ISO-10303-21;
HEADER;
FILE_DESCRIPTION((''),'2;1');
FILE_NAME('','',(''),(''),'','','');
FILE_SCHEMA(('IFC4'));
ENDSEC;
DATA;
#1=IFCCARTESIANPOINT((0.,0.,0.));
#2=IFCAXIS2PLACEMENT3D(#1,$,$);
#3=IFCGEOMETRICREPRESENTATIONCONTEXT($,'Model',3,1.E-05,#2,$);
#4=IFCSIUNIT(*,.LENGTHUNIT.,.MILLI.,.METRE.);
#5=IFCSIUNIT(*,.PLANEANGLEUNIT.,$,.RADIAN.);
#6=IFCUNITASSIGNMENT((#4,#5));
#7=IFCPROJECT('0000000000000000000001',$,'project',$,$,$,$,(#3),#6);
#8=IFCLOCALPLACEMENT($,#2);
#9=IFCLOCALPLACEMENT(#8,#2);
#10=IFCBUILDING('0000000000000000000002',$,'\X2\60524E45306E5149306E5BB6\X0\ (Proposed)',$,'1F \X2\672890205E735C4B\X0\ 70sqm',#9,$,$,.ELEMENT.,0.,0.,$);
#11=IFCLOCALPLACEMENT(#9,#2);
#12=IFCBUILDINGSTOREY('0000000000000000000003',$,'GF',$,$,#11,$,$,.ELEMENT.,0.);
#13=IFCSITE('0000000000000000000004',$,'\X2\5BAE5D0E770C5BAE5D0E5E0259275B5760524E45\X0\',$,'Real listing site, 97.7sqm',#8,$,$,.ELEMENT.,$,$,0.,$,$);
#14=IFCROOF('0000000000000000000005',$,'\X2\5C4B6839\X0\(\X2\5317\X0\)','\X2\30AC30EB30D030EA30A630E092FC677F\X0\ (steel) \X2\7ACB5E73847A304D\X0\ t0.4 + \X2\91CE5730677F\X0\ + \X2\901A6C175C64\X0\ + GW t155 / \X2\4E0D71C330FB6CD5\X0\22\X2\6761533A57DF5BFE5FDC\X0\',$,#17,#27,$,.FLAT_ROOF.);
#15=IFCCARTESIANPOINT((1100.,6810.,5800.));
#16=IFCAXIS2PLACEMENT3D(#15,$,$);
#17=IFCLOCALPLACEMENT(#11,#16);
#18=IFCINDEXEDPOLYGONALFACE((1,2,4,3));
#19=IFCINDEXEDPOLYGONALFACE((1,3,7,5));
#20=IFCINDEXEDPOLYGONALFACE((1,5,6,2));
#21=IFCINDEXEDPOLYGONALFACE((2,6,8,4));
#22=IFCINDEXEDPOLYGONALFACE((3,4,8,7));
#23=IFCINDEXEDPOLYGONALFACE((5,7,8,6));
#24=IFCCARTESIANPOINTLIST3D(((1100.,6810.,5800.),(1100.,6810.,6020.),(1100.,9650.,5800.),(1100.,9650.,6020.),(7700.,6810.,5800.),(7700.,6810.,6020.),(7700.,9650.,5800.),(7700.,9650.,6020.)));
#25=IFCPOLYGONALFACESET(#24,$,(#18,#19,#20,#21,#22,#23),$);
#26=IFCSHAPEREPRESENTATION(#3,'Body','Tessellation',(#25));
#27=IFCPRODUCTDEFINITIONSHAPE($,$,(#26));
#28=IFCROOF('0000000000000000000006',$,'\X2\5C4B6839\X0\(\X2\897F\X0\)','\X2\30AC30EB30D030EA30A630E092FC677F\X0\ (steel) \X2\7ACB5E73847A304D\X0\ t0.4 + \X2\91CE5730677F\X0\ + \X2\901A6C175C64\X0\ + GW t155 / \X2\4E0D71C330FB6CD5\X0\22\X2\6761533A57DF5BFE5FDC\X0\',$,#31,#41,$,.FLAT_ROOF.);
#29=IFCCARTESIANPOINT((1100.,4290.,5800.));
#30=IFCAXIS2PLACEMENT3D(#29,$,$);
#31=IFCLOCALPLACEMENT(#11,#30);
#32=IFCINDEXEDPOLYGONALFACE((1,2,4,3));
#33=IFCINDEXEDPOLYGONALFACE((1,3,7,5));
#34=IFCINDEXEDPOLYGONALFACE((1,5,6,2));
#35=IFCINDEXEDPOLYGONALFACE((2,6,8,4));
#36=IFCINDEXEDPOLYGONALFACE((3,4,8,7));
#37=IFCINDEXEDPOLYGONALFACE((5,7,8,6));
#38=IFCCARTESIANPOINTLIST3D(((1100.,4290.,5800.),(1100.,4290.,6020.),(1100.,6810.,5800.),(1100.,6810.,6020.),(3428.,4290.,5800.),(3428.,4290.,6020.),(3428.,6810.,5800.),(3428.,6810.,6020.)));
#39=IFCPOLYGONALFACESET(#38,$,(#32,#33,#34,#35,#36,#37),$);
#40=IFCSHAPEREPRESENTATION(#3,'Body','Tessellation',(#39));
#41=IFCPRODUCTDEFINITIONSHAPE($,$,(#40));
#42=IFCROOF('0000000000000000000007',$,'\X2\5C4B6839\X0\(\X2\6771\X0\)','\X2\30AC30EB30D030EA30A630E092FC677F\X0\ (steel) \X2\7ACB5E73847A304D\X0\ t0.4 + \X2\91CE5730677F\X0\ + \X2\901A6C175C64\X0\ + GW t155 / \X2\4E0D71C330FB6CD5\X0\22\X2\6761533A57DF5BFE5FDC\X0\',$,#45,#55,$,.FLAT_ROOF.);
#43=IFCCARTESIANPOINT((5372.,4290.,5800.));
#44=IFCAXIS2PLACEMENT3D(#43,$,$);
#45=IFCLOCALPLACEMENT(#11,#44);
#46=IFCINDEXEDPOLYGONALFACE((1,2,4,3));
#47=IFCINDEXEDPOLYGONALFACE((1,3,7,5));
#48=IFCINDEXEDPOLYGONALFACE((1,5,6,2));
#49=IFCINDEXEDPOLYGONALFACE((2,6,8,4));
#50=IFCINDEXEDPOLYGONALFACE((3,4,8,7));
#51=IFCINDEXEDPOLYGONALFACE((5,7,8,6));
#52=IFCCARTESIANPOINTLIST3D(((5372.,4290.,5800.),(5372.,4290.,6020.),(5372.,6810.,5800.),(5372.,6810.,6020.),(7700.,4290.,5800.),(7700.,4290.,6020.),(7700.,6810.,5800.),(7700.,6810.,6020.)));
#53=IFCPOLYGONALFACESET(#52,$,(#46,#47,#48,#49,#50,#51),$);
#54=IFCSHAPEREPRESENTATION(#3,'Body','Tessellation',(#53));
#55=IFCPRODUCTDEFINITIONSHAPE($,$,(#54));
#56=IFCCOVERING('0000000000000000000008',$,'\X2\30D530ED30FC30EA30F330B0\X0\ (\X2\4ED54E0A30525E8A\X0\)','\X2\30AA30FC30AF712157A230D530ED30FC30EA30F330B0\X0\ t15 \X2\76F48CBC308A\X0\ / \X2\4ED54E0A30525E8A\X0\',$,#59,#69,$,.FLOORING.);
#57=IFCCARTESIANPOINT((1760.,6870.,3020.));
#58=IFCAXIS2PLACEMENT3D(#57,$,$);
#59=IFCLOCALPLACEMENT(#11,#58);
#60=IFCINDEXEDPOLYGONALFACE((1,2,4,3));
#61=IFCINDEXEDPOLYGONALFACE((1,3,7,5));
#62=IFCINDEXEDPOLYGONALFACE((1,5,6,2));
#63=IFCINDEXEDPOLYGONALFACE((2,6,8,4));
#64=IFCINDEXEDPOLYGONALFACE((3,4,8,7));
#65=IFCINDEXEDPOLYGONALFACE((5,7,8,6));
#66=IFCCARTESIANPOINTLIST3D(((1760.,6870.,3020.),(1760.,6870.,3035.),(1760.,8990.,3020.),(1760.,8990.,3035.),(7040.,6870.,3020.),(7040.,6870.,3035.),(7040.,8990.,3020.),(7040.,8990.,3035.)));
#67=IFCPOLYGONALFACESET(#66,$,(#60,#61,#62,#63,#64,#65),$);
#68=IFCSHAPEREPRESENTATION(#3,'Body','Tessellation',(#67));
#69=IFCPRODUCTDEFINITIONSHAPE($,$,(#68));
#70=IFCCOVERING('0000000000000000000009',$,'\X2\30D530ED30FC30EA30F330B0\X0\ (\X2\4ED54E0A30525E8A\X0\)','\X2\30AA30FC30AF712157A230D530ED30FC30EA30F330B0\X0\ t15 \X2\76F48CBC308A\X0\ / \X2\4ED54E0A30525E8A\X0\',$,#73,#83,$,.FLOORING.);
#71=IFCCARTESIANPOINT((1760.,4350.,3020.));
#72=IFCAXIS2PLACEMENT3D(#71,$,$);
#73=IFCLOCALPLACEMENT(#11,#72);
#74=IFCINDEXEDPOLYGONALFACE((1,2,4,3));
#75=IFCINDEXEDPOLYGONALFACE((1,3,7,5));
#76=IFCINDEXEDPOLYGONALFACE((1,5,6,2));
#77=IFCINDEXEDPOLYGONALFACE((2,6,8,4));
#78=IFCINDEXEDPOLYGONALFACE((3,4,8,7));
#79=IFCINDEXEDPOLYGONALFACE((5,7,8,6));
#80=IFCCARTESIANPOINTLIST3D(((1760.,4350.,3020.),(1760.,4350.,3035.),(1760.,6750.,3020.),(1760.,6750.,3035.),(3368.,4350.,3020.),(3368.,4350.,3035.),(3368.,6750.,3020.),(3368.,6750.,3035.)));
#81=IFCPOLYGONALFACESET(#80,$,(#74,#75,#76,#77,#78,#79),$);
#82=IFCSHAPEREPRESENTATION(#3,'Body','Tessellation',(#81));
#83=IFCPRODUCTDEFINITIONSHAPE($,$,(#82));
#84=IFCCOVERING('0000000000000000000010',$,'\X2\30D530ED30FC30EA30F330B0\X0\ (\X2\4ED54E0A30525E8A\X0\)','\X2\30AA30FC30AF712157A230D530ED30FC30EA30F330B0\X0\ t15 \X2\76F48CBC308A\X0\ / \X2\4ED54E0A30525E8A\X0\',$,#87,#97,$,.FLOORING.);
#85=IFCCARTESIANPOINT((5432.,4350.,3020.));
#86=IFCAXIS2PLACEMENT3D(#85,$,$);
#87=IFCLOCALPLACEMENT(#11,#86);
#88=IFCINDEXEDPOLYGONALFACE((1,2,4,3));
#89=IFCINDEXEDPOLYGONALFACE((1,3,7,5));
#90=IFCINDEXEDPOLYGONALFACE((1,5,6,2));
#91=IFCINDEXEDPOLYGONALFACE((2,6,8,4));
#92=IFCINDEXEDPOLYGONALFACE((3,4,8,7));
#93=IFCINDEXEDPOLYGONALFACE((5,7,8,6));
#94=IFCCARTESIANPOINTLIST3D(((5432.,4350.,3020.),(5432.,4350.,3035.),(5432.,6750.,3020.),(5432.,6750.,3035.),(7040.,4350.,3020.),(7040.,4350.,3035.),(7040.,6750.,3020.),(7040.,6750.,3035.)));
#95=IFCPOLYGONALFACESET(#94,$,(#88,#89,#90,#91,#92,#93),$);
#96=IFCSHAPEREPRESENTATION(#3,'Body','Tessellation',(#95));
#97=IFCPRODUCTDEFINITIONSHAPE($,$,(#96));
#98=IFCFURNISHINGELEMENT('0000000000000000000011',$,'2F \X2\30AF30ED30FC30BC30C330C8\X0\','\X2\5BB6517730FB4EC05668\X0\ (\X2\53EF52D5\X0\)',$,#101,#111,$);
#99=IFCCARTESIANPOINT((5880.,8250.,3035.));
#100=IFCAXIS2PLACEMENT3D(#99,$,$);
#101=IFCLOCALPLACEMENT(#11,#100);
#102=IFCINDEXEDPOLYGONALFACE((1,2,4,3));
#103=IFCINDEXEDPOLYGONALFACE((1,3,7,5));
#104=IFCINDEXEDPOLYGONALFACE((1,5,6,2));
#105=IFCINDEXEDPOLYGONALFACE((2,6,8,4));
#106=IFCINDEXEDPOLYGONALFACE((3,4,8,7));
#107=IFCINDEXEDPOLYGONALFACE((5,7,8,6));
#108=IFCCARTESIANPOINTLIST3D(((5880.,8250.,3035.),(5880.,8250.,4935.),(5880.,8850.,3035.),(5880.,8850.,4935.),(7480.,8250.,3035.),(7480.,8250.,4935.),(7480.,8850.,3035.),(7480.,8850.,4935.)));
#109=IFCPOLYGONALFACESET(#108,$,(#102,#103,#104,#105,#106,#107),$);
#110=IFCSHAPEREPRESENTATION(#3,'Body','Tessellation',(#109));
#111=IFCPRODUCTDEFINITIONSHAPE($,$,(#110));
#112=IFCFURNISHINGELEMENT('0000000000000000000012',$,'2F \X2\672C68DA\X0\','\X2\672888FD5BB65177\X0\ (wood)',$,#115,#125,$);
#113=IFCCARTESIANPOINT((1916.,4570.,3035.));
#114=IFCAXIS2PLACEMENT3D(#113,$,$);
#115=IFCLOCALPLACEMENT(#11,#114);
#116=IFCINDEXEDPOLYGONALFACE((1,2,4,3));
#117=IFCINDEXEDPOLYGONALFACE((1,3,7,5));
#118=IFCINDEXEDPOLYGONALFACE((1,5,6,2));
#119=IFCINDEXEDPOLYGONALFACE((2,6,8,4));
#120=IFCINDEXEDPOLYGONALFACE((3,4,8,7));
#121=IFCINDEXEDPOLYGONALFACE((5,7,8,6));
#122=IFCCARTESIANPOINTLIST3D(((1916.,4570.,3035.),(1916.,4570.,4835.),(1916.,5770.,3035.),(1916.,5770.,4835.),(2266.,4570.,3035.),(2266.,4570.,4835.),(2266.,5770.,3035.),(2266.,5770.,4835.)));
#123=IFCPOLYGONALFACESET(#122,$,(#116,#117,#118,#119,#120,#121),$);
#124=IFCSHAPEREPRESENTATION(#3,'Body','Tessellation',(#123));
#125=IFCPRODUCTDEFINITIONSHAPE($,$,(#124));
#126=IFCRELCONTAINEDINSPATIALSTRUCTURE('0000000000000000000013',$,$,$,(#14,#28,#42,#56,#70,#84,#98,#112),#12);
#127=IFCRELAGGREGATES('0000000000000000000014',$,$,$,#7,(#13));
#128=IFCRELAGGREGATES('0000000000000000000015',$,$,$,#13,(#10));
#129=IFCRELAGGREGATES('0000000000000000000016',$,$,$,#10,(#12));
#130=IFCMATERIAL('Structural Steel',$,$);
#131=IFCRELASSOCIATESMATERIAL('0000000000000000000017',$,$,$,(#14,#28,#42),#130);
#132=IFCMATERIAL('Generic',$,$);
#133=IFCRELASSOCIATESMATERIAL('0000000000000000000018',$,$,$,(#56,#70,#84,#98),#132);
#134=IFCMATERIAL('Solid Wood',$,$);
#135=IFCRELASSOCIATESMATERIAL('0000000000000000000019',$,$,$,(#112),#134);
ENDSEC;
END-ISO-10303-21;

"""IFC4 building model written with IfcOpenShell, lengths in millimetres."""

from ifc_helpers import new_model, si_unit, frame, frame_2d, origin, place, context, project, spatial, rectangle, extrude, material, element, save


model = new_model("IFC4")

# Units and contexts
model_context = context("Model", 3, precision=1e-05, world=origin())
ifc_project = project(units=[si_unit("LENGTHUNIT", "METRE", prefix="MILLI"), si_unit("PLANEANGLEUNIT", "RADIAN")], contexts=[model_context])

# Site, building, storey
site_placement = place(None, origin())
site = spatial("IfcSite", under=ifc_project, at=site_placement, Name="宮崎県宮崎市大字恒久", ObjectType="Real listing site, 97.7sqm", CompositionType="ELEMENT", RefElevation=0.0)
building_placement = place(site_placement, origin())
building = spatial("IfcBuilding", under=site, at=building_placement, Name="恒久の光の家 (Proposed)", ObjectType="1F 木造平屋 70sqm", CompositionType="ELEMENT", ElevationOfRefHeight=0.0, ElevationOfTerrain=0.0)
storey_placement = place(building_placement, origin())
storey = spatial("IfcBuildingStorey", under=building, at=storey_placement, Name="GF", CompositionType="ELEMENT", Elevation=0.0)

# Shared definitions
ifc_material_1 = material(Name="Solid Wood")

# Shared definitions
ifc_material_2 = material(Name="Generic")

# Roofs
ifc_material_3 = material(Name="Structural Steel")
for number, where, name in (
    (1, (1100.0, 6810.0, 5800.0), "屋根(北)"),
):
    element("IfcRoof", number, at=place(storey_placement, frame(where)), inside=storey, material=ifc_material_3, Name=name, Description="ガルバリウム鋼板 (steel) 立平葺き t0.4 + 野地板 + 通気層 + GW t155 / 不燃・法22条区域対応", PredefinedType="FLAT_ROOF", context=model_context, shape_type="SweptSolid", body=[
        extrude(rectangle(XDim=6600.0, YDim=2840.0, at=frame_2d((3300.0, 1420.0))), frame((1100.0, 6810.0, 5800.0)), (0.0, 0.0, 1.0), 220.0),
    ])
roof_1_placement = place(storey_placement, frame((1100.0, 4290.0, 5800.0)))
element("IfcRoof", 2, at=roof_1_placement, inside=storey, material=ifc_material_3, Name="屋根(西)", Description="ガルバリウム鋼板 (steel) 立平葺き t0.4 + 野地板 + 通気層 + GW t155 / 不燃・法22条区域対応", PredefinedType="FLAT_ROOF", context=model_context, shape_type="SweptSolid", body=[
    extrude(rectangle(XDim=2328.0, YDim=2520.0, at=frame_2d((1164.0, 1260.0))), frame((1100.0, 4290.0, 5800.0)), (0.0, 0.0, 1.0), 220.0),
])
roof_2_placement = place(storey_placement, frame((5372.0, 4290.0, 5800.0)))
element("IfcRoof", 3, at=roof_2_placement, inside=storey, material=ifc_material_3, Name="屋根(東)", Description="ガルバリウム鋼板 (steel) 立平葺き t0.4 + 野地板 + 通気層 + GW t155 / 不燃・法22条区域対応", PredefinedType="FLAT_ROOF", context=model_context, shape_type="SweptSolid", body=[
    extrude(rectangle(XDim=2328.0, YDim=2520.0, at=frame_2d((1164.0, 1260.0))), frame((5372.0, 4290.0, 5800.0)), (0.0, 0.0, 1.0), 220.0),
])

# Coverings
covering_1_placement = place(storey_placement, frame((1760.0, 6870.0, 3020.0)))
element("IfcCovering", 4, at=covering_1_placement, inside=storey, material=ifc_material_2, Name="フローリング (仕上げ床)", Description="オーク無垢フローリング t15 直貼り / 仕上げ床", PredefinedType="FLOORING", context=model_context, shape_type="SweptSolid", body=[
    extrude(rectangle(XDim=5280.0, YDim=2120.0, at=frame_2d((2640.0, 1060.0))), frame((1760.0, 6870.0, 3020.0)), (0.0, 0.0, 1.0), 15.0),
])
covering_2_placement = place(storey_placement, frame((1760.0, 4350.0, 3020.0)))
element("IfcCovering", 5, at=covering_2_placement, inside=storey, material=ifc_material_2, Name="フローリング (仕上げ床)", Description="オーク無垢フローリング t15 直貼り / 仕上げ床", PredefinedType="FLOORING", context=model_context, shape_type="SweptSolid", body=[
    extrude(rectangle(XDim=1608.0, YDim=2400.0, at=frame_2d((804.0, 1200.0))), frame((1760.0, 4350.0, 3020.0)), (0.0, 0.0, 1.0), 15.0),
])
covering_3_placement = place(storey_placement, frame((5432.0, 4350.0, 3020.0)))
element("IfcCovering", 6, at=covering_3_placement, inside=storey, material=ifc_material_2, Name="フローリング (仕上げ床)", Description="オーク無垢フローリング t15 直貼り / 仕上げ床", PredefinedType="FLOORING", context=model_context, shape_type="SweptSolid", body=[
    extrude(rectangle(XDim=1608.0, YDim=2400.0, at=frame_2d((804.0, 1200.0))), frame((5432.0, 4350.0, 3020.0)), (0.0, 0.0, 1.0), 15.0),
])

# Furnishing elements
furnishing_1_placement = place(storey_placement, frame((5880.0, 8250.0, 3035.0)))
element("IfcFurnishingElement", 7, at=furnishing_1_placement, inside=storey, material=ifc_material_2, Name="2F クローゼット", Description="家具・什器 (可動)", context=model_context, shape_type="SweptSolid", body=[
    extrude(rectangle(XDim=1600.0, YDim=600.0, at=frame_2d((800.0, 300.0))), frame((5880.0, 8250.0, 3035.0)), (0.0, 0.0, 1.0), 1900.0),
])
furnishing_2_placement = place(storey_placement, frame((1916.0, 4570.0, 3035.0)))
element("IfcFurnishingElement", 8, at=furnishing_2_placement, inside=storey, material=ifc_material_1, Name="2F 本棚", Description="木製家具 (wood)", context=model_context, shape_type="SweptSolid", body=[
    extrude(rectangle(XDim=350.0, YDim=1200.0, at=frame_2d((175.0, 600.0))), frame((1916.0, 4570.0, 3035.0)), (0.0, 0.0, 1.0), 1800.0),
])

save(model, "model.ifc")
